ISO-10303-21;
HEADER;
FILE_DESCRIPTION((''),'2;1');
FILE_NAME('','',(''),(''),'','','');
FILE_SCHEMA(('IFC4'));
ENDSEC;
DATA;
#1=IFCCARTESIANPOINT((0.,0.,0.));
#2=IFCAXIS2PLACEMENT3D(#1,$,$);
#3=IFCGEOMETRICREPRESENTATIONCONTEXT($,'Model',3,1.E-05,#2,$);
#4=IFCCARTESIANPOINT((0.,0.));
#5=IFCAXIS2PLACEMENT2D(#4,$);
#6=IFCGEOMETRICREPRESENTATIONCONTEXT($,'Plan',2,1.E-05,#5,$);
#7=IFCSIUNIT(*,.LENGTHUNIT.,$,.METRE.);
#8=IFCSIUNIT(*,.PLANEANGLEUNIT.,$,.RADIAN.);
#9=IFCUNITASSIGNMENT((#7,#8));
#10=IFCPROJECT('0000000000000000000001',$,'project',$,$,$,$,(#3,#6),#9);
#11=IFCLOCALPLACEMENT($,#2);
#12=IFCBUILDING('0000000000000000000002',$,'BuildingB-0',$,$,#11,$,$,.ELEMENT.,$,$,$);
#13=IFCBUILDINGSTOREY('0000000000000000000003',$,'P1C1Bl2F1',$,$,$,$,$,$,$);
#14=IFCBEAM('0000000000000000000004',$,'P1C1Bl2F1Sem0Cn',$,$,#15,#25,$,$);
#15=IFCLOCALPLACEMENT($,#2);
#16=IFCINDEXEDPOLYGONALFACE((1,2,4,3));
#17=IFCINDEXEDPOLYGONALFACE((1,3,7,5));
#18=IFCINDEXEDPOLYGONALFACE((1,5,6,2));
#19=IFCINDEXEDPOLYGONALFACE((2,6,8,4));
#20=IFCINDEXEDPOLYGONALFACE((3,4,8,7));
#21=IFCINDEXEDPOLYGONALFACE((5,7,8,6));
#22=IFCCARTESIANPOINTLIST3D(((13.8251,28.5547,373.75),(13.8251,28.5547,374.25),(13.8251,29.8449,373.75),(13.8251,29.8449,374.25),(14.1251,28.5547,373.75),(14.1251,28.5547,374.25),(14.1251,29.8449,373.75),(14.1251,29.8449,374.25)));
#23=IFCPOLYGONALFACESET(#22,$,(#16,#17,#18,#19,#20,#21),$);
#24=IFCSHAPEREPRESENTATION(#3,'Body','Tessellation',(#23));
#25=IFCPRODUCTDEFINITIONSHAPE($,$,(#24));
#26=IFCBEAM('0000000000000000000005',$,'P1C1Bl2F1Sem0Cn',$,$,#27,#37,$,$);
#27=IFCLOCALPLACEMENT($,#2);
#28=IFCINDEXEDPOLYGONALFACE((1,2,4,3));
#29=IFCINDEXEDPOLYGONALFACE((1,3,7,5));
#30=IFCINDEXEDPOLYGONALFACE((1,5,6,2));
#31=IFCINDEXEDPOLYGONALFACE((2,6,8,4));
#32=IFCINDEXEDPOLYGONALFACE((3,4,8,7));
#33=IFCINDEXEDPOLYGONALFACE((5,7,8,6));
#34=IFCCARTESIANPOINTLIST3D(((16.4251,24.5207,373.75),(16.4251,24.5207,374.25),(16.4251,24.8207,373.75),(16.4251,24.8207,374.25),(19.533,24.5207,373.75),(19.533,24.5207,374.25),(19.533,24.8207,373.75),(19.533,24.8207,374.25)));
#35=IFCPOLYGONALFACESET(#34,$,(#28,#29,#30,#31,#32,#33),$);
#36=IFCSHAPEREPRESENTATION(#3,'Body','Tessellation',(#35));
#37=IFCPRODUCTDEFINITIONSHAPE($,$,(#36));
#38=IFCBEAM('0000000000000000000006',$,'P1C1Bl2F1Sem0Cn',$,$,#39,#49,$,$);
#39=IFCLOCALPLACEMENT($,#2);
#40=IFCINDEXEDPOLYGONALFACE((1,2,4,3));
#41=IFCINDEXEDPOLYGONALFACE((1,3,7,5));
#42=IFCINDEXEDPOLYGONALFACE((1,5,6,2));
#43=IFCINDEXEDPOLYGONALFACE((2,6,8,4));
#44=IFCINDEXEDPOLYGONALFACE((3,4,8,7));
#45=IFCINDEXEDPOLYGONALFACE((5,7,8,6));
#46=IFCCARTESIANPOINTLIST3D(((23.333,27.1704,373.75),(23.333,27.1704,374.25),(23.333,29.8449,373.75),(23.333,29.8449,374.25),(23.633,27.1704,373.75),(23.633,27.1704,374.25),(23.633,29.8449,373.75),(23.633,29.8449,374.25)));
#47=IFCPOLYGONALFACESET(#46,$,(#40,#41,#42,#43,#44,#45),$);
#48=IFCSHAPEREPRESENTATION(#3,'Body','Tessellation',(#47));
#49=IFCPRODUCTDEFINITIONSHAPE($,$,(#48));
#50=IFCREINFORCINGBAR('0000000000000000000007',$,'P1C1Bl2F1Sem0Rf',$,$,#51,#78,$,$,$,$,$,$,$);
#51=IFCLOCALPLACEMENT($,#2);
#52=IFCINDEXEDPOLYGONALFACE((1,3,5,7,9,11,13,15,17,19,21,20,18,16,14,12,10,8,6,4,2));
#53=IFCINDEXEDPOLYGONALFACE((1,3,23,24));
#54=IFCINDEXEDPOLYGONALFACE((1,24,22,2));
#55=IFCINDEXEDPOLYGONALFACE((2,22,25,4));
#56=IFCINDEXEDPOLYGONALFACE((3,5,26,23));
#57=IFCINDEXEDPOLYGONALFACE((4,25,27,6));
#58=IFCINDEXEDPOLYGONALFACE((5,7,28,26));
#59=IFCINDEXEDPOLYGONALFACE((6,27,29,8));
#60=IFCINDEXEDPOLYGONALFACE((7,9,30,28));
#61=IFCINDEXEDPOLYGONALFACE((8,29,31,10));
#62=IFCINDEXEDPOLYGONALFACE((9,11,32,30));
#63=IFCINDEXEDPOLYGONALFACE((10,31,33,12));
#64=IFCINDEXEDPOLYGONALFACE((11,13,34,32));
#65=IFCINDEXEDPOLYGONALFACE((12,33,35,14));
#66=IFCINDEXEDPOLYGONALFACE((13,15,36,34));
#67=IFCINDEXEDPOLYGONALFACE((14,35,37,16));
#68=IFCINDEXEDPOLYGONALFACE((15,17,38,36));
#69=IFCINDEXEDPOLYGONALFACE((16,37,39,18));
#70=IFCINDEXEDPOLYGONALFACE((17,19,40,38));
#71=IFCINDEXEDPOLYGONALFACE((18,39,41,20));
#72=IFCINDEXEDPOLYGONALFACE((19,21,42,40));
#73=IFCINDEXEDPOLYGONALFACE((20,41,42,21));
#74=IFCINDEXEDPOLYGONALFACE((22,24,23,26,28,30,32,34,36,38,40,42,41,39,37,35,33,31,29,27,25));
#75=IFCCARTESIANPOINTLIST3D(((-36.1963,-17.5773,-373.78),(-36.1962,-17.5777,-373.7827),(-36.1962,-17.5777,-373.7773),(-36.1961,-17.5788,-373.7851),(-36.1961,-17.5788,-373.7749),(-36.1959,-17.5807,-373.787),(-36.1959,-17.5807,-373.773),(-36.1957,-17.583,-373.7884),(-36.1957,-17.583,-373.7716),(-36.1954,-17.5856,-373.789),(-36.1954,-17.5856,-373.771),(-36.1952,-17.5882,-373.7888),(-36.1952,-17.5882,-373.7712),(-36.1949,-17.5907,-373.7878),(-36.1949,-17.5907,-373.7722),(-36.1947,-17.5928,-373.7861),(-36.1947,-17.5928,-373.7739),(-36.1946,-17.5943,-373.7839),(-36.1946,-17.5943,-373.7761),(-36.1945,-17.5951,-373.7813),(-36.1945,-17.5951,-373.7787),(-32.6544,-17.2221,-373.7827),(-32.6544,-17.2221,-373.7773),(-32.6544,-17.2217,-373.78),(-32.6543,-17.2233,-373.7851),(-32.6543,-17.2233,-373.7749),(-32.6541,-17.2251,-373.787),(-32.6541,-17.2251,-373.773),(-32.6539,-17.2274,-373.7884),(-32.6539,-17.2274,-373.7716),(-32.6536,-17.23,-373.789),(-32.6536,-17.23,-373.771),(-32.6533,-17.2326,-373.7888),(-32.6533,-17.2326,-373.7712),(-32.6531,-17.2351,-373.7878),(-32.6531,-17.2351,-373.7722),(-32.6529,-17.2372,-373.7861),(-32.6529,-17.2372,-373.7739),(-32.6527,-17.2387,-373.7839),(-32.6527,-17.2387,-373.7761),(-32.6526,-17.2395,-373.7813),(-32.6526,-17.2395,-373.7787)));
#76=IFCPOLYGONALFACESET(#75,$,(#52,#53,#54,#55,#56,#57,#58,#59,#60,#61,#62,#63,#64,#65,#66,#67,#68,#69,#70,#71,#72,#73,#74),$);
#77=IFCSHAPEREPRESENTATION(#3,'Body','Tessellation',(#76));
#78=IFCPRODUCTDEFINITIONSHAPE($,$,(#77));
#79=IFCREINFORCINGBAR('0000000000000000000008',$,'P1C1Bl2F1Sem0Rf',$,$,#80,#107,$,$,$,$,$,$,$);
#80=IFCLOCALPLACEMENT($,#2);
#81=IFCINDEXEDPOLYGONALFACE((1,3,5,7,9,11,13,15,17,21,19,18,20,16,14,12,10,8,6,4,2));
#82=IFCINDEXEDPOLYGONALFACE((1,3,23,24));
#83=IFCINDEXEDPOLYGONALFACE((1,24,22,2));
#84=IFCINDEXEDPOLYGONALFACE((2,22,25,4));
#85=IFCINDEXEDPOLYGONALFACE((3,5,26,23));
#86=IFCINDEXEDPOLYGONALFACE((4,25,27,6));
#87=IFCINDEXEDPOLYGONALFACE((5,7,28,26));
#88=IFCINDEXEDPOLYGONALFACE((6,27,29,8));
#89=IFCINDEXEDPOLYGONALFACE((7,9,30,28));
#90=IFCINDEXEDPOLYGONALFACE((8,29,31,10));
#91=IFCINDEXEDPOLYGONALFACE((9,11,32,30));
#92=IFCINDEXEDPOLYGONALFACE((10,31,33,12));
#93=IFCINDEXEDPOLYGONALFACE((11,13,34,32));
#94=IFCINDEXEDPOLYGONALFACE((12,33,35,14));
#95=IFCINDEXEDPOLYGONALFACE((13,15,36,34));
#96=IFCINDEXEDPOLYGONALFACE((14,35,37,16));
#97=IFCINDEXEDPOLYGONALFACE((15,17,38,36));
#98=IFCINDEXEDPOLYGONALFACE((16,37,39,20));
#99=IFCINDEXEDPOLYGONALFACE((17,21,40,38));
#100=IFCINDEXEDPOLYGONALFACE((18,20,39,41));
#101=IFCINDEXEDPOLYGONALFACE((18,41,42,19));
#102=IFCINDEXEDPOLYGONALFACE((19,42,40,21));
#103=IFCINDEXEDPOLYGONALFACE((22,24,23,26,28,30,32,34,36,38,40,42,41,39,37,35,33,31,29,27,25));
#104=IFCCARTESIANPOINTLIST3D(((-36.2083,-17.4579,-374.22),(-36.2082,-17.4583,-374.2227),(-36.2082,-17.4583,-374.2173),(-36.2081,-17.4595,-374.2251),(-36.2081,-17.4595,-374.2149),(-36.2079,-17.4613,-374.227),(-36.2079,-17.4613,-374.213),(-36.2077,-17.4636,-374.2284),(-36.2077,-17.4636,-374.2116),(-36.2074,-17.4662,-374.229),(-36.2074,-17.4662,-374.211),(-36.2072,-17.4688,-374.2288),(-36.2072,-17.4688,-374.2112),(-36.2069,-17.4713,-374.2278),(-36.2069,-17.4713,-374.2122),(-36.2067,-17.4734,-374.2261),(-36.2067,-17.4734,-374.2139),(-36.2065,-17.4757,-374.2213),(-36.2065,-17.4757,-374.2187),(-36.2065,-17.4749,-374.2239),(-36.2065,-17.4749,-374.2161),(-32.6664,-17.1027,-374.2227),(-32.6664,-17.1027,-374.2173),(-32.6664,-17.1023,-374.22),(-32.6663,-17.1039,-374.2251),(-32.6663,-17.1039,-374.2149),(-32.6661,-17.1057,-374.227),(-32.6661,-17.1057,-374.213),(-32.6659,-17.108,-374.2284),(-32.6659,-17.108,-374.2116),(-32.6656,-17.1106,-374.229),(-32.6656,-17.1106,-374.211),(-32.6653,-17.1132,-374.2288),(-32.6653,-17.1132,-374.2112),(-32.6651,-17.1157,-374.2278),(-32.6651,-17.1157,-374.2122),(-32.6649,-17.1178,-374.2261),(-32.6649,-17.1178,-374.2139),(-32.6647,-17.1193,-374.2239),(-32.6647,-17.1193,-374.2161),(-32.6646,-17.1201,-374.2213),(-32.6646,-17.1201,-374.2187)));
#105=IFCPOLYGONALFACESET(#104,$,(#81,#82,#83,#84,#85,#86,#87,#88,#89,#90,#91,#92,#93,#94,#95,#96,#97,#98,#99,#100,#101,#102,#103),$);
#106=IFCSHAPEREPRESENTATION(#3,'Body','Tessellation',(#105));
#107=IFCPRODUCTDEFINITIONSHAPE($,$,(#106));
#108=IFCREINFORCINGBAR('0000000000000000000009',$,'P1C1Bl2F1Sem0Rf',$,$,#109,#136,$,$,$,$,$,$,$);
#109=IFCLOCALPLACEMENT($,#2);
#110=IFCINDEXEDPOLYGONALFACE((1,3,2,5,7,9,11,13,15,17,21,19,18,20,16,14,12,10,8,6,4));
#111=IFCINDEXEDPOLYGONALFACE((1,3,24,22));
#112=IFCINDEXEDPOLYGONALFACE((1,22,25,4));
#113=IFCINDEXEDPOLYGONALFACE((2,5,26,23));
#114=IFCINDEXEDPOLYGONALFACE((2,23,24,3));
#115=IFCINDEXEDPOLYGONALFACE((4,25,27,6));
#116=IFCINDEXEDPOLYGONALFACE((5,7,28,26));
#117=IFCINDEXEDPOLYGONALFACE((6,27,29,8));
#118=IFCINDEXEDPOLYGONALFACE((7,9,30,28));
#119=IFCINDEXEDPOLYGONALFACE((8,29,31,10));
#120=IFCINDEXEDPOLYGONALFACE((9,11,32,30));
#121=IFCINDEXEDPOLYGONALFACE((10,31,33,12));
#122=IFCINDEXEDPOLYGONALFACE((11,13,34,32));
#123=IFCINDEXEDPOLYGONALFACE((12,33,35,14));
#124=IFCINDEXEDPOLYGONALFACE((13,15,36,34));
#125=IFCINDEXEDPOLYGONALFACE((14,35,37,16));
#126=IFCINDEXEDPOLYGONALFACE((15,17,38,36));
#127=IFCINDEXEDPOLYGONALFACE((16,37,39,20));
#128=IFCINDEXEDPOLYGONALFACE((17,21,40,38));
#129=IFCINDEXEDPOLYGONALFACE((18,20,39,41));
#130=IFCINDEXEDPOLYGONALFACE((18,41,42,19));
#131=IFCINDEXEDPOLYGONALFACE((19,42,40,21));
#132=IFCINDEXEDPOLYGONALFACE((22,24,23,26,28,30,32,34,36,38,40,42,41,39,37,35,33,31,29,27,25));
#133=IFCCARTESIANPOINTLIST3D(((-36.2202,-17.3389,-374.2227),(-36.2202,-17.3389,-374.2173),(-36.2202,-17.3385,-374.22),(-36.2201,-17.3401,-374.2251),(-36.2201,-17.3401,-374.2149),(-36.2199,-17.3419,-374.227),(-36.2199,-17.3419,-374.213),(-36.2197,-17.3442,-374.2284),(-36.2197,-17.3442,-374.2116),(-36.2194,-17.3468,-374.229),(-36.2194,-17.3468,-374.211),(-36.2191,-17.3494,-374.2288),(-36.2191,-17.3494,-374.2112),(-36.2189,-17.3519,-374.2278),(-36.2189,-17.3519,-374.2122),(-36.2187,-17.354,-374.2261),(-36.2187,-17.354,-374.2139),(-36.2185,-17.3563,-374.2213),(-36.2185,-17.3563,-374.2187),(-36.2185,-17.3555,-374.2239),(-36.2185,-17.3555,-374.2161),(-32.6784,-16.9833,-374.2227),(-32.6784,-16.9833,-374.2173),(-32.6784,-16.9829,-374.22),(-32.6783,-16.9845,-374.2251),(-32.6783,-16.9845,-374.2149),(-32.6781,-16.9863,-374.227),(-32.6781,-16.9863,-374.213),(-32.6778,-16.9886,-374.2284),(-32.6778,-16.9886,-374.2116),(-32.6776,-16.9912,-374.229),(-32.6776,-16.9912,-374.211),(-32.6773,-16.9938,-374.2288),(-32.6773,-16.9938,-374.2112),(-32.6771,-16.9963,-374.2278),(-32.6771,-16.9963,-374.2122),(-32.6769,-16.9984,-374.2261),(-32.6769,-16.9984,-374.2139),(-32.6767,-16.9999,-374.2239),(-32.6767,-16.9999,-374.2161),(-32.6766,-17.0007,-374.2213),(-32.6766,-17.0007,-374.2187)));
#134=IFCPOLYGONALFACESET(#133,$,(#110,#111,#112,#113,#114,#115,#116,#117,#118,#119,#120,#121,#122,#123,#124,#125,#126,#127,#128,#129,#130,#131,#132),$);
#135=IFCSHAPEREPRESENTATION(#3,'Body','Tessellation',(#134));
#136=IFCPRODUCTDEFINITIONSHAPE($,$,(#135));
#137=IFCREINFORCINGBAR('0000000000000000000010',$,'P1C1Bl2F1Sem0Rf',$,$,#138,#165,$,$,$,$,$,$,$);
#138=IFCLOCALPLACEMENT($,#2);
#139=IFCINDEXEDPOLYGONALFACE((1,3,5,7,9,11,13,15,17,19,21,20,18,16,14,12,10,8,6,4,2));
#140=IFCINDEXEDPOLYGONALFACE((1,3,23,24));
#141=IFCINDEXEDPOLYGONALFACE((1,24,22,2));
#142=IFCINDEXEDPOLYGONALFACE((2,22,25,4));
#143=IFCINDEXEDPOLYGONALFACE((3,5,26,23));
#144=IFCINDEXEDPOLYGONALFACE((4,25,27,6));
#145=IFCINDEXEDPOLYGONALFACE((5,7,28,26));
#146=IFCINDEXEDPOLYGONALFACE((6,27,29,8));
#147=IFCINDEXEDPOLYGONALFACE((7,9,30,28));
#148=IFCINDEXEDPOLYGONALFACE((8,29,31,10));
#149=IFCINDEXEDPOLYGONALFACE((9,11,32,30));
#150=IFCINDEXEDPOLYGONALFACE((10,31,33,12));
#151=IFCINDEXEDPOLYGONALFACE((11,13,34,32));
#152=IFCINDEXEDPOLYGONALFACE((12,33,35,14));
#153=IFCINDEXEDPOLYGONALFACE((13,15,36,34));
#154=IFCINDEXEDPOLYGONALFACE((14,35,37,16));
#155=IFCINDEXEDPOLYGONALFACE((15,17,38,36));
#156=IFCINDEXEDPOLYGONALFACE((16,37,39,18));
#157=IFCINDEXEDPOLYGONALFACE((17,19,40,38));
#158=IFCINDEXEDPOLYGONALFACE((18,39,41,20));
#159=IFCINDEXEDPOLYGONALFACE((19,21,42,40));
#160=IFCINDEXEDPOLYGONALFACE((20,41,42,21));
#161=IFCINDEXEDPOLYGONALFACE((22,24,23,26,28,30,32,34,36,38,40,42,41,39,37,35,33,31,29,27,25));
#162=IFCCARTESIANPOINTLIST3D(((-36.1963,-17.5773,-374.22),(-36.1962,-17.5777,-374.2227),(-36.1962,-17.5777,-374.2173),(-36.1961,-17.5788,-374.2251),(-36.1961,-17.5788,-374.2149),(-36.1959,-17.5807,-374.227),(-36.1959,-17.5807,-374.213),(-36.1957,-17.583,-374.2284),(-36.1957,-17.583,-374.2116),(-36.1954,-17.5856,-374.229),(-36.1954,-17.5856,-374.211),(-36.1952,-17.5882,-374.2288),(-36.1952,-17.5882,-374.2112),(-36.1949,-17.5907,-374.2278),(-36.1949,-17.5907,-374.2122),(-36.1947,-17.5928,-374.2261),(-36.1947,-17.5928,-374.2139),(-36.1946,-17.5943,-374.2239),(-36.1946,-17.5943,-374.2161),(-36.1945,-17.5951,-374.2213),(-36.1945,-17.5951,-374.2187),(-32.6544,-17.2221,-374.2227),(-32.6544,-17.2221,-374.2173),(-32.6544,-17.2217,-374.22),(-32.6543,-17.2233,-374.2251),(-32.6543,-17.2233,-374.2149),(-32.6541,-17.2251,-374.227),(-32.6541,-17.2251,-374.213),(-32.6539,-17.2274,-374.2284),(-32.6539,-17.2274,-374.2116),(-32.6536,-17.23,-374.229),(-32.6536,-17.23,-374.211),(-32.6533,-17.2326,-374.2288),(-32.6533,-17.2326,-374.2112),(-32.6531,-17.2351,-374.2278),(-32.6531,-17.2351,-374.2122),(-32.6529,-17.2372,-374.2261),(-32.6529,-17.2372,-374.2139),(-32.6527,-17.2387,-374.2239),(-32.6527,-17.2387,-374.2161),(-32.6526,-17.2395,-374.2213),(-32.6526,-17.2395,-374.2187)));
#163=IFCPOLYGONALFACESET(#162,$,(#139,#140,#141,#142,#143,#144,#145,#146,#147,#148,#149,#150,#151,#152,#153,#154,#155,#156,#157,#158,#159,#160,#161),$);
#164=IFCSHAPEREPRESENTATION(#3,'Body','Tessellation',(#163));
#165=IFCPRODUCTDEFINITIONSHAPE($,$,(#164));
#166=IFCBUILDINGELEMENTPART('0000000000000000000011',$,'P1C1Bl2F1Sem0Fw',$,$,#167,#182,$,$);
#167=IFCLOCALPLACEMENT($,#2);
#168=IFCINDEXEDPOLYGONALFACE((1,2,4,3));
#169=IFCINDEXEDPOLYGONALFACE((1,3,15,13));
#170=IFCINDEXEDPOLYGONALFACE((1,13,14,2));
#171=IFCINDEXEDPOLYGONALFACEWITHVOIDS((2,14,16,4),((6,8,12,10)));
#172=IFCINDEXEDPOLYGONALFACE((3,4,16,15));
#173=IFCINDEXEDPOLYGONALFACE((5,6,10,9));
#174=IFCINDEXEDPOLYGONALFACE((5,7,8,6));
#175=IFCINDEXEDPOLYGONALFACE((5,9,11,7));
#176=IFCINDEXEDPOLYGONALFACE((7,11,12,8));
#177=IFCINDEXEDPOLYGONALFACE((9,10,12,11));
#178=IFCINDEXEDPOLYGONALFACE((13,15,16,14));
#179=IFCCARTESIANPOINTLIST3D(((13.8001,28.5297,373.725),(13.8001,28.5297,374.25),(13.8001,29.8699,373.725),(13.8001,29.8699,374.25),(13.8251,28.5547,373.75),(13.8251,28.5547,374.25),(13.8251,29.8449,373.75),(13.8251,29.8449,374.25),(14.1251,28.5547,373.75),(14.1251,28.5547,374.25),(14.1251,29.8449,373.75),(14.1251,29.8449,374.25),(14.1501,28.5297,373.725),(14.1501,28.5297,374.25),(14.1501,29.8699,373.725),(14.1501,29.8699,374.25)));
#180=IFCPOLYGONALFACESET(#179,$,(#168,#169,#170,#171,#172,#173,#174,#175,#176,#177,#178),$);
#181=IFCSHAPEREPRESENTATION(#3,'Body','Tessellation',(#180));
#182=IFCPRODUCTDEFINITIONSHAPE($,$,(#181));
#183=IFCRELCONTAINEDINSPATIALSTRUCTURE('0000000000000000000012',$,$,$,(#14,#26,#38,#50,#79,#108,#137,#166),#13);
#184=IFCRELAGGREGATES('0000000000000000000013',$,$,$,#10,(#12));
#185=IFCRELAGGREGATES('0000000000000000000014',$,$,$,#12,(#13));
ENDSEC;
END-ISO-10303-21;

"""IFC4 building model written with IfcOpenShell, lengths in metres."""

from ifc_helpers import new_model, entity, si_unit, origin, origin_2d, place, context, project, spatial, polyline, outline, extrude, element, save


model = new_model("IFC4")

# Units and contexts
model_context = context("Model", 3, precision=1e-05, world=origin())
plan_context = context("Plan", 2, precision=1e-05, world=origin_2d())
ifc_project = project(units=[si_unit("LENGTHUNIT", "METRE"), si_unit("PLANEANGLEUNIT", "RADIAN")], contexts=[model_context, plan_context])

# Building, storey
building_placement = place(None, origin())
building = spatial("IfcBuilding", under=ifc_project, at=building_placement, Name="BuildingB-0", CompositionType="ELEMENT")
storey = spatial("IfcBuildingStorey", under=building, Name="P1C1Bl2F1")

# Beams
element("IfcBeam", 1, inside=storey, Name="P1C1Bl2F1Sem0Cn", context=model_context, shape_type="SweptSolid", body=[
    extrude(outline(polyline([(13.8251, 28.5547, 373.75), (14.1251, 28.5547, 373.75), (14.1251, 29.8449, 373.75), (13.8251, 29.8449, 373.75), (13.8251, 28.5547, 373.75)])), None, (0.0, 0.0, 1.0), 0.5),
])
element("IfcBeam", 2, inside=storey, Name="P1C1Bl2F1Sem0Cn", context=model_context, shape_type="SweptSolid", body=[
    extrude(outline(polyline([(16.4251, 24.5207, 373.75), (16.4251, 24.8207, 373.75), (19.533, 24.8207, 373.75), (19.533, 24.5207, 373.75), (16.4251, 24.5207, 373.75)])), None, (0.0, 0.0, 1.0), 0.5),
])
element("IfcBeam", 3, inside=storey, Name="P1C1Bl2F1Sem0Cn", context=model_context, shape_type="SweptSolid", body=[
    extrude(outline(polyline([(23.333, 27.1704, 373.75), (23.633, 27.1704, 373.75), (23.633, 29.8449, 373.75), (23.333, 29.8449, 373.75), (23.333, 27.1704, 373.75)])), None, (0.0, 0.0, 1.0), 0.5),
])

# Reinforcing bars
element("IfcReinforcingBar", 4, inside=storey, Name="P1C1Bl2F1Sem0Rf", context=model_context, shape_type="SweptSolid", body=[
    entity("IfcSurfaceCurveSweptAreaSolid", entity("IfcCircleProfileDef", "AREA", None, None, 0.009), None, entity("IfcPolyline", [entity("IfcCartesianPoint", [32.6535, 17.2306, 373.78]), entity("IfcCartesianPoint", [36.1954, 17.5862, 373.78])]), None, None, entity("IfcPlane", entity("IfcAxis2Placement3D", entity("IfcCartesianPoint", [32.6535, 17.2306, 373.78]), entity("IfcDirection", [0.0, 0.0, 1.0]), entity("IfcDirection", [1.0, 0.0, 0.0])))),
])
element("IfcReinforcingBar", 5, inside=storey, Name="P1C1Bl2F1Sem0Rf", context=model_context, shape_type="SweptSolid", body=[
    entity("IfcSurfaceCurveSweptAreaSolid", entity("IfcCircleProfileDef", "AREA", None, None, 0.009), None, entity("IfcPolyline", [entity("IfcCartesianPoint", [32.6655, 17.1112, 374.22]), entity("IfcCartesianPoint", [36.2074, 17.4668, 374.22])]), None, None, entity("IfcPlane", entity("IfcAxis2Placement3D", entity("IfcCartesianPoint", [32.6655, 17.1112, 374.22]), entity("IfcDirection", [0.0, 0.0, 1.0]), entity("IfcDirection", [1.0, 0.0, 0.0])))),
])
element("IfcReinforcingBar", 6, inside=storey, Name="P1C1Bl2F1Sem0Rf", context=model_context, shape_type="SweptSolid", body=[
    entity("IfcSurfaceCurveSweptAreaSolid", entity("IfcCircleProfileDef", "AREA", None, None, 0.009), None, entity("IfcPolyline", [entity("IfcCartesianPoint", [32.6775, 16.9918, 374.22]), entity("IfcCartesianPoint", [36.2193, 17.3474, 374.22])]), None, None, entity("IfcPlane", entity("IfcAxis2Placement3D", entity("IfcCartesianPoint", [32.6775, 16.9918, 374.22]), entity("IfcDirection", [0.0, 0.0, 1.0]), entity("IfcDirection", [1.0, 0.0, 0.0])))),
])
element("IfcReinforcingBar", 7, inside=storey, Name="P1C1Bl2F1Sem0Rf", context=model_context, shape_type="SweptSolid", body=[
    entity("IfcSurfaceCurveSweptAreaSolid", entity("IfcCircleProfileDef", "AREA", None, None, 0.009), None, entity("IfcPolyline", [entity("IfcCartesianPoint", [32.6535, 17.2306, 374.22]), entity("IfcCartesianPoint", [36.1954, 17.5862, 374.22])]), None, None, entity("IfcPlane", entity("IfcAxis2Placement3D", entity("IfcCartesianPoint", [32.6535, 17.2306, 374.22]), entity("IfcDirection", [0.0, 0.0, 1.0]), entity("IfcDirection", [1.0, 0.0, 0.0])))),
])

# Building element part, opening
building_element_part_1 = element("IfcBuildingElementPart", 8, inside=storey, Name="P1C1Bl2F1Sem0Fw", context=model_context, shape_type="SweptSolid", body=[
    extrude(outline(polyline([(13.8001, 28.5297, 373.725), (14.1501, 28.5297, 373.725), (14.1501, 29.8699, 373.725), (13.8001, 29.8699, 373.725), (13.8001, 28.5297, 373.725)])), None, (0.0, 0.0, 1.0), 0.525),
])
element("IfcOpeningElement", 9, inside=storey, cuts=building_element_part_1, context=model_context, shape_type="SweptSolid", body=[
    extrude(outline(polyline([(13.8251, 28.5547, 373.75), (14.1251, 28.5547, 373.75), (14.1251, 29.8449, 373.75), (13.8251, 29.8449, 373.75), (13.8251, 28.5547, 373.75)])), None, (0.0, 0.0, 1.0), 0.5),
])

save(model, "model.ifc")
